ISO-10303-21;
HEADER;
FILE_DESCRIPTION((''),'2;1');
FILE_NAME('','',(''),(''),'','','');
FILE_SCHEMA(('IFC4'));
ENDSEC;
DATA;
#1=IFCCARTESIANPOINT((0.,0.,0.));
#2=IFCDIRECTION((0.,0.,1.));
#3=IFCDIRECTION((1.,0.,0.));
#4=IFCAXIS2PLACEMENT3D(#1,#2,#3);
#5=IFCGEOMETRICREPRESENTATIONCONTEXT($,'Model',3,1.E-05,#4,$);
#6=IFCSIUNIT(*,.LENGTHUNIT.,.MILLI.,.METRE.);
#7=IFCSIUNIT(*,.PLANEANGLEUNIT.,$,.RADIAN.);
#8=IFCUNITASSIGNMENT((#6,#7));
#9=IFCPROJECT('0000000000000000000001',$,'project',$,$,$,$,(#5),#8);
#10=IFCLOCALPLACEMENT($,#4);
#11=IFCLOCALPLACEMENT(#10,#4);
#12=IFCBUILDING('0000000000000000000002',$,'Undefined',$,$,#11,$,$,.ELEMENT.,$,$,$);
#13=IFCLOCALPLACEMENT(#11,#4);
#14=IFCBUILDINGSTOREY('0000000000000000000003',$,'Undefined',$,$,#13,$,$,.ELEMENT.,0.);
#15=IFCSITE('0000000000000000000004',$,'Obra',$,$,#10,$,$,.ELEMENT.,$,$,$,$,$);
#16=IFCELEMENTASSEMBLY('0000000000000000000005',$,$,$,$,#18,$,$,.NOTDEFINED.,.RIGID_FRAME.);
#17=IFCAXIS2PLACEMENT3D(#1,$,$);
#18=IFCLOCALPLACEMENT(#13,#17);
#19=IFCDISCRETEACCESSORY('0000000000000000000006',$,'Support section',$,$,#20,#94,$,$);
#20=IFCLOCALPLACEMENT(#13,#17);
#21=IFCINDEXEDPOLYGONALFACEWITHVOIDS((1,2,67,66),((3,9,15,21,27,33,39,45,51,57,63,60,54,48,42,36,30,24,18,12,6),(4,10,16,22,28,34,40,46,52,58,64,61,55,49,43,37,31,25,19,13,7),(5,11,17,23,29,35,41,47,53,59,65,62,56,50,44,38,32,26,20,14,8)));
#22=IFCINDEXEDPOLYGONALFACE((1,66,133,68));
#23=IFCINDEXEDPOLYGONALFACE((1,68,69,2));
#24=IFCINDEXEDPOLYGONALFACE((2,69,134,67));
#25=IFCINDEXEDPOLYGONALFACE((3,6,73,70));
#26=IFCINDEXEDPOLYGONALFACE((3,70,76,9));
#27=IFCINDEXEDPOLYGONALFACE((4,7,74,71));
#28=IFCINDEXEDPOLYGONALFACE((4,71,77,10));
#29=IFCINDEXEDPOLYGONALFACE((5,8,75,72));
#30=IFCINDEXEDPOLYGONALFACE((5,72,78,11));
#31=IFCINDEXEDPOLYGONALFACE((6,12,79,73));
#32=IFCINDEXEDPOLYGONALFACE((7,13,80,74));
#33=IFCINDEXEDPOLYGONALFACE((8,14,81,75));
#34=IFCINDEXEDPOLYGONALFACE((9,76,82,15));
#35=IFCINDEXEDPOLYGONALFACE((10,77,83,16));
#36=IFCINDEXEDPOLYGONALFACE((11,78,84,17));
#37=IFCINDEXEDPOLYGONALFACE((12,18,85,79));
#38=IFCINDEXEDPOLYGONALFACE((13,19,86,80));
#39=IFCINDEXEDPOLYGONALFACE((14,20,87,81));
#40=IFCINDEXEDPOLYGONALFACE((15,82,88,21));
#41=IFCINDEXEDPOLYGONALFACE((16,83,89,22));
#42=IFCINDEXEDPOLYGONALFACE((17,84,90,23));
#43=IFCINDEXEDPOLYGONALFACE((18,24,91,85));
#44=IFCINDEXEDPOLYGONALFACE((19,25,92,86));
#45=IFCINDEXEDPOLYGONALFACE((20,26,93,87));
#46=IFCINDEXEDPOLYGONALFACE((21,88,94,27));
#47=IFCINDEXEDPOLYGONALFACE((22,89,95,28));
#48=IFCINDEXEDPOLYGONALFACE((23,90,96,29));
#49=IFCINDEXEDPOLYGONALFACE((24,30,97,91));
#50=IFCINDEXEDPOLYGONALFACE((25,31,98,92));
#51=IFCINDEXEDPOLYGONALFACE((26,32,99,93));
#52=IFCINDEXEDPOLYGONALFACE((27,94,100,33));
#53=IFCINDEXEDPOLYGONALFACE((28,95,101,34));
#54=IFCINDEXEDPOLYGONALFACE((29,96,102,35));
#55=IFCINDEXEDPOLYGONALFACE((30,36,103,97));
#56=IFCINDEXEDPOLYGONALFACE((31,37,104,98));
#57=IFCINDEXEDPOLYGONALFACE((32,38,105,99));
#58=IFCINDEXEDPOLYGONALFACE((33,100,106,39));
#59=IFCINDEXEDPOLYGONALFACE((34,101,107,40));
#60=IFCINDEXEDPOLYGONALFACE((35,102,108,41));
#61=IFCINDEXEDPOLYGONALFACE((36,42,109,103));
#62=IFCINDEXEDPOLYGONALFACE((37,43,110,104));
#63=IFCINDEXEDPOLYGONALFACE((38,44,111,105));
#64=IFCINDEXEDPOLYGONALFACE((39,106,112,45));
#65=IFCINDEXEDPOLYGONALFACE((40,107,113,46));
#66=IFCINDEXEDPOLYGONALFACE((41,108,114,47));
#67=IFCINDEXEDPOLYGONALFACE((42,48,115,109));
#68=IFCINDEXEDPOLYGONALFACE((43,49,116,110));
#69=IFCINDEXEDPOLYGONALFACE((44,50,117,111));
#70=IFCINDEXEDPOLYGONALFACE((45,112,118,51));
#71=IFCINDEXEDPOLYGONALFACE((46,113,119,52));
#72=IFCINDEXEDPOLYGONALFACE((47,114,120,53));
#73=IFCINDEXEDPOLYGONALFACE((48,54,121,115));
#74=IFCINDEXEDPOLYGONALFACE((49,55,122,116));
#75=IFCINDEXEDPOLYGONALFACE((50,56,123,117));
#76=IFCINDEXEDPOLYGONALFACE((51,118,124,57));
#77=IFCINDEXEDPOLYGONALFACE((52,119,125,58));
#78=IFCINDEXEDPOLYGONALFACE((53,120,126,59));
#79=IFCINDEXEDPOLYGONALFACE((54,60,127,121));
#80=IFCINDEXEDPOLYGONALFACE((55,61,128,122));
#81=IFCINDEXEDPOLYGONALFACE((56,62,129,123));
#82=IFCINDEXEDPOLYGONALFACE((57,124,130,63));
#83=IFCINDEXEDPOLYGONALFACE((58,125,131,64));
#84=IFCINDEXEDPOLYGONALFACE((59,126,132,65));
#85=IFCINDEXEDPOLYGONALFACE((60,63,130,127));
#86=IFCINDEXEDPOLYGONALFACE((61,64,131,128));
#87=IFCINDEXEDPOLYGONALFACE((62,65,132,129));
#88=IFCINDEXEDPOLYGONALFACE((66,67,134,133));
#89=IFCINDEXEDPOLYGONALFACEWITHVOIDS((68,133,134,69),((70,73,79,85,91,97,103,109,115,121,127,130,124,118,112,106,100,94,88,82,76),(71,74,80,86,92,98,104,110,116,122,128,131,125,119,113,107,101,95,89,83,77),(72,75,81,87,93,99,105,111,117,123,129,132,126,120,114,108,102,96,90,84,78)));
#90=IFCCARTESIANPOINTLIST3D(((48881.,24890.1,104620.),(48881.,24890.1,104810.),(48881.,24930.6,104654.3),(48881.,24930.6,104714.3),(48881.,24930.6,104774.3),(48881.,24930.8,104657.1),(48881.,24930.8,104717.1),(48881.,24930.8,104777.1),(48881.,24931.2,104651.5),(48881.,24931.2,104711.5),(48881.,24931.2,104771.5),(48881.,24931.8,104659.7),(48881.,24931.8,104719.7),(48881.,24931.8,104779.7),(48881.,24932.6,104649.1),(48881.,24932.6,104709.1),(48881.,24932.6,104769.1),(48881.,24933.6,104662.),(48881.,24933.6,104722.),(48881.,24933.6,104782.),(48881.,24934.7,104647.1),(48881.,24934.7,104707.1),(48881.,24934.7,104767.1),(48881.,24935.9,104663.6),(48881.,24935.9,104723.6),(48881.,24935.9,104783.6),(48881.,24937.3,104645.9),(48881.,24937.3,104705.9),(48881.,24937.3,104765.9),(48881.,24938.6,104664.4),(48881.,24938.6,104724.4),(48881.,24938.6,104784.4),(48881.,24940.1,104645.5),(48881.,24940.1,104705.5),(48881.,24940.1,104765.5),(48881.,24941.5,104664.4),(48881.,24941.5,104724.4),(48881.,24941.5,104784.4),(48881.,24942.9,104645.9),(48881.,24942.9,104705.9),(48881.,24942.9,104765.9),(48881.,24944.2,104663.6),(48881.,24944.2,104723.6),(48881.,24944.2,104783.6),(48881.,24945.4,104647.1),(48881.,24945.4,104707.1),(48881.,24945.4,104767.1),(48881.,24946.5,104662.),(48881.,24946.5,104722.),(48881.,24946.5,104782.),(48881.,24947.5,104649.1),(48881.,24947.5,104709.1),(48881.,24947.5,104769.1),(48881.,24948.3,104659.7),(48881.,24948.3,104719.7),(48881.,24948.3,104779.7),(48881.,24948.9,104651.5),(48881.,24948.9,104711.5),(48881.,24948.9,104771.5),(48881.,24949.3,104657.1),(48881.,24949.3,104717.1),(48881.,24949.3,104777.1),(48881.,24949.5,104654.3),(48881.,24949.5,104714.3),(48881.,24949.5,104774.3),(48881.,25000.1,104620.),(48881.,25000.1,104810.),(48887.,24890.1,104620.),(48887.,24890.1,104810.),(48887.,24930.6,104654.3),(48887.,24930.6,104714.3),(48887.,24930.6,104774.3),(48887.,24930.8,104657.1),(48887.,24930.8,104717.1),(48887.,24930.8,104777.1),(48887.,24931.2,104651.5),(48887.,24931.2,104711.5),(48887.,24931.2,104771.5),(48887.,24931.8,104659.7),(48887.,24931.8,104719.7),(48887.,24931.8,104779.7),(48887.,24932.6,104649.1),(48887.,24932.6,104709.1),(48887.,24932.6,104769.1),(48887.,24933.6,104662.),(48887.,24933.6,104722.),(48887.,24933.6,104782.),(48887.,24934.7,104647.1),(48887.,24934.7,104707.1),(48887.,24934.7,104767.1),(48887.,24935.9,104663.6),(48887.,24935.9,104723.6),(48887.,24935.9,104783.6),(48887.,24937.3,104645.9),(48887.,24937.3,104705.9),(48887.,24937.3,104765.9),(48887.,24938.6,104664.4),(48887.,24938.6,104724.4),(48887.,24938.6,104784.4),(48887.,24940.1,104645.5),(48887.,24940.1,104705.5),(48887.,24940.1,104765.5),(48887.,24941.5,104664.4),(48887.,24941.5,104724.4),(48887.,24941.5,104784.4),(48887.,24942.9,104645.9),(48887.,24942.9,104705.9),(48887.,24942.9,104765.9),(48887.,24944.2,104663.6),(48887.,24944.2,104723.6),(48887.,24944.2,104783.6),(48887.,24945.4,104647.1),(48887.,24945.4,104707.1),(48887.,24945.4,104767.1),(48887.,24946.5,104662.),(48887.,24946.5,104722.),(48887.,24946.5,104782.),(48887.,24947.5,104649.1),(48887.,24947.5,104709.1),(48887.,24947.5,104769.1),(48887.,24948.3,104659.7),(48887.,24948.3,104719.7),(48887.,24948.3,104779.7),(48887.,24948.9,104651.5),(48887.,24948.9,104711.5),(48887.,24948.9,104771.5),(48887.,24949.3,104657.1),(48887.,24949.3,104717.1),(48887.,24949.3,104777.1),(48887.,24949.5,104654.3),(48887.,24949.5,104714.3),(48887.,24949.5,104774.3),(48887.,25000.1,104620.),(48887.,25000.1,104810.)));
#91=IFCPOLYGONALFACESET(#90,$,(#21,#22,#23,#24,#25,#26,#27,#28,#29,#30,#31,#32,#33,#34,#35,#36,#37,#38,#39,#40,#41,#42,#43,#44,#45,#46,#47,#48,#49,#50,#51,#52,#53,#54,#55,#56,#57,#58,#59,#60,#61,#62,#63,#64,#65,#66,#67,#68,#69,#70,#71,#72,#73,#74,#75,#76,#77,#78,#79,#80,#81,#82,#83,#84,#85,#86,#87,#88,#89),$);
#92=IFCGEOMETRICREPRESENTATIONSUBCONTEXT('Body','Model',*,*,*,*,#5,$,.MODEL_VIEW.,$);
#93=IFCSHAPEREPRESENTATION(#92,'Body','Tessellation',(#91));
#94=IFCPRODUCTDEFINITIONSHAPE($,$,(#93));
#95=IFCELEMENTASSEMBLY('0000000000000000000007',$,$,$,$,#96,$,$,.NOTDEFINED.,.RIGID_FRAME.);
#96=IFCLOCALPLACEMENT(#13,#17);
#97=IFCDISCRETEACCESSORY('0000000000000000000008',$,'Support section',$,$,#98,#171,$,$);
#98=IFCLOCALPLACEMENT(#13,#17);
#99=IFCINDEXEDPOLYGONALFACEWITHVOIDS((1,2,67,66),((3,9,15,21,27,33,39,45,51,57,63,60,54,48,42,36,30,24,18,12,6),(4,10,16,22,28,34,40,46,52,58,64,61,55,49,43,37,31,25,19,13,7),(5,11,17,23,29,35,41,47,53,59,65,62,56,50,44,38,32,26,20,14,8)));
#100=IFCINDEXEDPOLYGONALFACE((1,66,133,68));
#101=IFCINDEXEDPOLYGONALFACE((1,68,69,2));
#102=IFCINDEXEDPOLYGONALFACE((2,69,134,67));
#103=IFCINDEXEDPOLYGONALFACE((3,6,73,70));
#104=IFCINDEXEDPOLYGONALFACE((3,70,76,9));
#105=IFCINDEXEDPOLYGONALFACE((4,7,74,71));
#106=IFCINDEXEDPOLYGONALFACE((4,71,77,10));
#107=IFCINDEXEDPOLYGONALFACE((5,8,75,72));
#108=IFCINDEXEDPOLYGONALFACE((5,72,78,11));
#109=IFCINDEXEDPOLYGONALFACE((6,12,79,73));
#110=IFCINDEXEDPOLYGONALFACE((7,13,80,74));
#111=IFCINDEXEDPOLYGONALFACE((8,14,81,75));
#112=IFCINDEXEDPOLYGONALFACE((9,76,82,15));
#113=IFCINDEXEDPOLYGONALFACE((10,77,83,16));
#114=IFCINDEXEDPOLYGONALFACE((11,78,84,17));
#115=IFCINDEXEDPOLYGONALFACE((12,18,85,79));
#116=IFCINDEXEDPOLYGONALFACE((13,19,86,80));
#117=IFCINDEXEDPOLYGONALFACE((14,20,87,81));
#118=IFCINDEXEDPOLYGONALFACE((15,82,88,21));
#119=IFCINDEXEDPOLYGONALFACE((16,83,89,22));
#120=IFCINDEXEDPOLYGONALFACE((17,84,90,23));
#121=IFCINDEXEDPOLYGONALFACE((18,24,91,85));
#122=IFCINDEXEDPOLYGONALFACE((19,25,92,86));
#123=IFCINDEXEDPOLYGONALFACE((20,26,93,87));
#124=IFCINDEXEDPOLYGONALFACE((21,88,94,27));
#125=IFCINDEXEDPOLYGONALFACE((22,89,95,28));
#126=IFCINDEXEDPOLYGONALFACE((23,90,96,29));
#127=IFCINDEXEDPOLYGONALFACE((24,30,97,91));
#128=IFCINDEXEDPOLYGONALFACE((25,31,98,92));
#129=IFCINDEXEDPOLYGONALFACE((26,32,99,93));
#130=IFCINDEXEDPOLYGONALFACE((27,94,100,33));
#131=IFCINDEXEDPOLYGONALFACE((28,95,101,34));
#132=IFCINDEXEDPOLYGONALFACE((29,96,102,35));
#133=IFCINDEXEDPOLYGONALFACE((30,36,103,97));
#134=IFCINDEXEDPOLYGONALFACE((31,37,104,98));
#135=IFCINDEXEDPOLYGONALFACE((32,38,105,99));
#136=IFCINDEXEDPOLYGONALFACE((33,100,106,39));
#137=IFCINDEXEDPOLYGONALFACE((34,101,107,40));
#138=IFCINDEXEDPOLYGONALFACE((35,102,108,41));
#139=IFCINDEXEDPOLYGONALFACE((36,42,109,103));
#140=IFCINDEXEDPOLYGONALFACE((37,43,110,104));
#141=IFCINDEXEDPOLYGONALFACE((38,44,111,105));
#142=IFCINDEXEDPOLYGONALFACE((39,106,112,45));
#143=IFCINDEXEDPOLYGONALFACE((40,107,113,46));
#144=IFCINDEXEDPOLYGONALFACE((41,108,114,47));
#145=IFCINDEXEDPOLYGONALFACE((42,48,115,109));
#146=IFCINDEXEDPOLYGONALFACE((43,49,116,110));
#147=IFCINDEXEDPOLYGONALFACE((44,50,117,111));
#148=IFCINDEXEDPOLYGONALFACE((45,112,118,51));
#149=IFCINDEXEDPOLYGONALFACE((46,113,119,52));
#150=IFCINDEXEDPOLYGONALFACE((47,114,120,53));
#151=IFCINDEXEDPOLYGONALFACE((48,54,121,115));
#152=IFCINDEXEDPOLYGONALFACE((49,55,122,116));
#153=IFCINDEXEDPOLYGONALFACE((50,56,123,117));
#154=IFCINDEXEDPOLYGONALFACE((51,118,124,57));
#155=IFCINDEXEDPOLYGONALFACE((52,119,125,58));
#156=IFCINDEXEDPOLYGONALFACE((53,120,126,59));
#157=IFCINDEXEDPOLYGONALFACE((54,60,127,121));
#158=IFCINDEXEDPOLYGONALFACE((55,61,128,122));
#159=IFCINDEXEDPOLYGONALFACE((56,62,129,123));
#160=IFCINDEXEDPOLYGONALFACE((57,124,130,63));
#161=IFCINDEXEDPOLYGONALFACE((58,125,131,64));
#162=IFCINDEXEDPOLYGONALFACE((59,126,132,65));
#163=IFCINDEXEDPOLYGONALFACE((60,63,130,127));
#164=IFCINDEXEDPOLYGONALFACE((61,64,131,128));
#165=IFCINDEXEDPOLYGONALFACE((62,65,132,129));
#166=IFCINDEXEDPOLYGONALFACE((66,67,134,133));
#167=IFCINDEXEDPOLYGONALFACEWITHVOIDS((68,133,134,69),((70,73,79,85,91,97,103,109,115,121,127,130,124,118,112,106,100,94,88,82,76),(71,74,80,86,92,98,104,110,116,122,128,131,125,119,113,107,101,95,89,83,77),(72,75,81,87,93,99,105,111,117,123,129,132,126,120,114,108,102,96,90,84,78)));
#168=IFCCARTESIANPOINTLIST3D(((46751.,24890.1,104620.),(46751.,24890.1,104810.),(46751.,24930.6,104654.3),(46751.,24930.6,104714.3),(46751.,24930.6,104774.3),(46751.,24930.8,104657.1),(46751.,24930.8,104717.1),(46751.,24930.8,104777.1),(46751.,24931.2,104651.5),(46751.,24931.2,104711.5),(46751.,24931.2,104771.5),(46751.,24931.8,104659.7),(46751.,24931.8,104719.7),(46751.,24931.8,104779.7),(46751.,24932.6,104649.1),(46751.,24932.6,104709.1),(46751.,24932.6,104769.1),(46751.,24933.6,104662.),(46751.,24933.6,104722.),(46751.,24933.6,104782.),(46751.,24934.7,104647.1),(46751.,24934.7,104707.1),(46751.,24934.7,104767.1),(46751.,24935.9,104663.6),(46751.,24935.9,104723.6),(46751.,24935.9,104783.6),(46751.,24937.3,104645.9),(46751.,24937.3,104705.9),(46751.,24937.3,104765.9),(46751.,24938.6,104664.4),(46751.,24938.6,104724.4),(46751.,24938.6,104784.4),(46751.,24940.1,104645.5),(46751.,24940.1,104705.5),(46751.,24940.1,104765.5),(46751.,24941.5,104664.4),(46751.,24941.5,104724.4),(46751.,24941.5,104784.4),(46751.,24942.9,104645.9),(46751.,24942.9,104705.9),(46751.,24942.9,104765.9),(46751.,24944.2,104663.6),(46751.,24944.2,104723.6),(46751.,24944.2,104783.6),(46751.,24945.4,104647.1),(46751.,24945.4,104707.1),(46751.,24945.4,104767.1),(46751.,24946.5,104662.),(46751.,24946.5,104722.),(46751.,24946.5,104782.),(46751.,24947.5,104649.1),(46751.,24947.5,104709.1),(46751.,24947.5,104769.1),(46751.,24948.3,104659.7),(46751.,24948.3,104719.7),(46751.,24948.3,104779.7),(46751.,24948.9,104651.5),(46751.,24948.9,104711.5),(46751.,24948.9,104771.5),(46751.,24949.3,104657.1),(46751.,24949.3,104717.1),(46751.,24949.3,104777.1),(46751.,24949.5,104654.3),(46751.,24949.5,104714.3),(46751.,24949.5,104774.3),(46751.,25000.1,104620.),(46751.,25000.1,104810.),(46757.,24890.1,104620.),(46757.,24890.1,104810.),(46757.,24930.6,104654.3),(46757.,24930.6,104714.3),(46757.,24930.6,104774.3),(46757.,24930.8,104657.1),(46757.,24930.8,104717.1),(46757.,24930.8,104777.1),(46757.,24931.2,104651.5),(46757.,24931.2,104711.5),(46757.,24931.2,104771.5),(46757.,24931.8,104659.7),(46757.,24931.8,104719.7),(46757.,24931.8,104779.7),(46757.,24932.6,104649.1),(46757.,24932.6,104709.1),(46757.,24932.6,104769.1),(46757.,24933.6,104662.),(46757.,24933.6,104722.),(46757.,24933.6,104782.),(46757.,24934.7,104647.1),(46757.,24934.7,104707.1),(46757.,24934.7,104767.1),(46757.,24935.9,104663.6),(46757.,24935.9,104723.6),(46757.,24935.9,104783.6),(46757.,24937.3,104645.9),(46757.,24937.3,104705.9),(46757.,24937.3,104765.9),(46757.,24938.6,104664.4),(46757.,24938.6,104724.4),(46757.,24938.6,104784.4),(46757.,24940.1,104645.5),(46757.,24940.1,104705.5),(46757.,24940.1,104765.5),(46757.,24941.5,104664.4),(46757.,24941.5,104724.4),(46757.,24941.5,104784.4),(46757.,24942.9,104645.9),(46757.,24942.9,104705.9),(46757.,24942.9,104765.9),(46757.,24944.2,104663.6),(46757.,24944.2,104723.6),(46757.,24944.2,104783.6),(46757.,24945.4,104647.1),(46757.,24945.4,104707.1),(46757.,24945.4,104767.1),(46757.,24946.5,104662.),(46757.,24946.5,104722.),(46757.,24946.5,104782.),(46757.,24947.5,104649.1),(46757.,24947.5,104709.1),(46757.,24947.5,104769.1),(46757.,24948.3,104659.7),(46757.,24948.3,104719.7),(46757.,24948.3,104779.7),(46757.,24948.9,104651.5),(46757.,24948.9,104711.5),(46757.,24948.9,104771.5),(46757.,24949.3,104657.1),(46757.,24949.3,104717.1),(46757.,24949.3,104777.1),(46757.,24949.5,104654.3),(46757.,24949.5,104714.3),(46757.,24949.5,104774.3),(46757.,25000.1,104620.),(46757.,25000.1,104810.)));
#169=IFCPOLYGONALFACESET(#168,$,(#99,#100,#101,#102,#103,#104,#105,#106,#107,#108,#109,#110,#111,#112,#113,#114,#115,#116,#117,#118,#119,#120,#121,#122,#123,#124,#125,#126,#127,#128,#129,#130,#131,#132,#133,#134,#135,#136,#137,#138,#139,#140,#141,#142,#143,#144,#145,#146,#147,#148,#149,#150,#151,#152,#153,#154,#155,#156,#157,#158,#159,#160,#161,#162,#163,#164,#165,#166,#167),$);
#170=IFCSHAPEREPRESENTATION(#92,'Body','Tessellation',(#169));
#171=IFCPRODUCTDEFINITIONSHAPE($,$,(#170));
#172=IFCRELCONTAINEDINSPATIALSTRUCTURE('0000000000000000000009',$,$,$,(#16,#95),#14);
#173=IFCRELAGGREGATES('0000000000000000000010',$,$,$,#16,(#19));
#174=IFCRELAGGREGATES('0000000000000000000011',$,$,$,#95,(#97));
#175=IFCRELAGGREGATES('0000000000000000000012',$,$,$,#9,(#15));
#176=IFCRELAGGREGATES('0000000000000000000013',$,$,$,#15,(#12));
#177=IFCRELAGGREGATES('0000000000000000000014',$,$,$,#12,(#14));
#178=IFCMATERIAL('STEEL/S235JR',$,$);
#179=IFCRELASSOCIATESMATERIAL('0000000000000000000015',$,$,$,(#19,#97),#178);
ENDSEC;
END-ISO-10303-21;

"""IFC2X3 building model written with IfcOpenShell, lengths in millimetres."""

from ifc_helpers import new_model, si_unit, frame, origin_with_axes, origin_2d_with_axis, place, context, subcontext, project, spatial, rectangle, circle, extrude, source, transform, mapped, material, element, aggregate, save


model = new_model("IFC2X3")

# Units and contexts
model_context = context("Model", 3, precision=1e-05, world=origin_with_axes())
body_context = subcontext(model_context, "Body", "Model", "MODEL_VIEW")
ifc_project = project(units=[si_unit("LENGTHUNIT", "METRE", prefix="MILLI"), si_unit("PLANEANGLEUNIT", "RADIAN")], contexts=[model_context])

# Site, building, storey
site_placement = place(None, origin_with_axes())
site = spatial("IfcSite", under=ifc_project, at=site_placement, Name="Obra", CompositionType="ELEMENT")
building_placement = place(site_placement, origin_with_axes())
building = spatial("IfcBuilding", under=site, at=building_placement, Name="Undefined", CompositionType="ELEMENT")
storey_placement = place(building_placement, origin_with_axes())
storey = spatial("IfcBuildingStorey", under=building, at=storey_placement, Name="Undefined", CompositionType="ELEMENT", Elevation=0.0)

# Shared definitions
ifc_material = material(Name="STEEL/S235JR")

# Element assemblies, discrete accessories, openings
shared_shape_1 = source(origin_with_axes(), body_context, "Body", "SweptSolid", [
    extrude(circle(Radius=9.5, at=origin_2d_with_axis()), frame((0.0, -9.2, 0.0), z_axis=(0.0, 1.0, 0.0), x_axis=(1.0, 0.0, 0.0)), (0.0, 0.0, 1.0), 6.2),
])
assembly_1_placement = place(storey_placement, origin_with_axes())
assembly_1 = element("IfcElementAssembly", 1, at=assembly_1_placement, inside=storey, AssemblyPlace="NOTDEFINED", PredefinedType="RIGID_FRAME")
discrete_accessory_1_placement = place(assembly_1_placement, frame((48884.0, 24945.1, 104620.0), z_axis=(0.0, 0.0, 1.0), x_axis=(-0.000002, 1.0, 0.0)))
discrete_accessory_1 = element("IfcDiscreteAccessory", 2, at=discrete_accessory_1_placement, material=ifc_material, Name="Support section", context=body_context, shape_type="SweptSolid", body=[
    extrude(rectangle(XDim=6.0, YDim=110.0, at=origin_2d_with_axis()), frame((0.0, 0.0, 190.0), z_axis=(0.0, 0.0, -1.0), x_axis=(0.0, 1.0, 0.0)), (0.0, 0.0, 1.0), 190.0),
])
opening_1_placement = place(assembly_1_placement, frame((48890.1, 24990.1, 104835.0), z_axis=(0.000002, -1.0, 0.0), x_axis=(0.0, 0.0, -1.0)))
element("IfcOpeningElement", 3, at=opening_1_placement, cuts=discrete_accessory_1, ObjectType="Opening", context=body_context, shape_type="MappedRepresentation", body=[
    mapped(shared_shape_1, transform((60.0, 0.0, 50.0))),
    mapped(shared_shape_1, transform((120.0, 0.0, 50.0))),
    mapped(shared_shape_1, transform((180.0, 0.0, 50.0))),
])
aggregate(assembly_1, [discrete_accessory_1])
assembly_2_placement = place(storey_placement, origin_with_axes())
assembly_2 = element("IfcElementAssembly", 4, at=assembly_2_placement, inside=storey, AssemblyPlace="NOTDEFINED", PredefinedType="RIGID_FRAME")
discrete_accessory_2_placement = place(assembly_2_placement, frame((46754.0, 24945.1, 104620.0), z_axis=(0.0, 0.0, 1.0), x_axis=(-0.000002, 1.0, 0.0)))
discrete_accessory_2 = element("IfcDiscreteAccessory", 5, at=discrete_accessory_2_placement, material=ifc_material, Name="Support section", context=body_context, shape_type="SweptSolid", body=[
    extrude(rectangle(XDim=6.0, YDim=110.0, at=origin_2d_with_axis()), frame((0.0, 0.0, 190.0), z_axis=(0.0, 0.0, -1.0), x_axis=(0.0, 1.0, 0.0)), (0.0, 0.0, 1.0), 190.0),
])
opening_2_placement = place(assembly_2_placement, frame((46760.1, 24990.1, 104835.0), z_axis=(0.000002, -1.0, 0.0), x_axis=(0.0, 0.0, -1.0)))
element("IfcOpeningElement", 6, at=opening_2_placement, cuts=discrete_accessory_2, ObjectType="Opening", context=body_context, shape_type="MappedRepresentation", body=[
    mapped(shared_shape_1, transform((60.0, 0.0, 50.0))),
    mapped(shared_shape_1, transform((120.0, 0.0, 50.0))),
    mapped(shared_shape_1, transform((180.0, 0.0, 50.0))),
])
aggregate(assembly_2, [discrete_accessory_2])

save(model, "model.ifc")
